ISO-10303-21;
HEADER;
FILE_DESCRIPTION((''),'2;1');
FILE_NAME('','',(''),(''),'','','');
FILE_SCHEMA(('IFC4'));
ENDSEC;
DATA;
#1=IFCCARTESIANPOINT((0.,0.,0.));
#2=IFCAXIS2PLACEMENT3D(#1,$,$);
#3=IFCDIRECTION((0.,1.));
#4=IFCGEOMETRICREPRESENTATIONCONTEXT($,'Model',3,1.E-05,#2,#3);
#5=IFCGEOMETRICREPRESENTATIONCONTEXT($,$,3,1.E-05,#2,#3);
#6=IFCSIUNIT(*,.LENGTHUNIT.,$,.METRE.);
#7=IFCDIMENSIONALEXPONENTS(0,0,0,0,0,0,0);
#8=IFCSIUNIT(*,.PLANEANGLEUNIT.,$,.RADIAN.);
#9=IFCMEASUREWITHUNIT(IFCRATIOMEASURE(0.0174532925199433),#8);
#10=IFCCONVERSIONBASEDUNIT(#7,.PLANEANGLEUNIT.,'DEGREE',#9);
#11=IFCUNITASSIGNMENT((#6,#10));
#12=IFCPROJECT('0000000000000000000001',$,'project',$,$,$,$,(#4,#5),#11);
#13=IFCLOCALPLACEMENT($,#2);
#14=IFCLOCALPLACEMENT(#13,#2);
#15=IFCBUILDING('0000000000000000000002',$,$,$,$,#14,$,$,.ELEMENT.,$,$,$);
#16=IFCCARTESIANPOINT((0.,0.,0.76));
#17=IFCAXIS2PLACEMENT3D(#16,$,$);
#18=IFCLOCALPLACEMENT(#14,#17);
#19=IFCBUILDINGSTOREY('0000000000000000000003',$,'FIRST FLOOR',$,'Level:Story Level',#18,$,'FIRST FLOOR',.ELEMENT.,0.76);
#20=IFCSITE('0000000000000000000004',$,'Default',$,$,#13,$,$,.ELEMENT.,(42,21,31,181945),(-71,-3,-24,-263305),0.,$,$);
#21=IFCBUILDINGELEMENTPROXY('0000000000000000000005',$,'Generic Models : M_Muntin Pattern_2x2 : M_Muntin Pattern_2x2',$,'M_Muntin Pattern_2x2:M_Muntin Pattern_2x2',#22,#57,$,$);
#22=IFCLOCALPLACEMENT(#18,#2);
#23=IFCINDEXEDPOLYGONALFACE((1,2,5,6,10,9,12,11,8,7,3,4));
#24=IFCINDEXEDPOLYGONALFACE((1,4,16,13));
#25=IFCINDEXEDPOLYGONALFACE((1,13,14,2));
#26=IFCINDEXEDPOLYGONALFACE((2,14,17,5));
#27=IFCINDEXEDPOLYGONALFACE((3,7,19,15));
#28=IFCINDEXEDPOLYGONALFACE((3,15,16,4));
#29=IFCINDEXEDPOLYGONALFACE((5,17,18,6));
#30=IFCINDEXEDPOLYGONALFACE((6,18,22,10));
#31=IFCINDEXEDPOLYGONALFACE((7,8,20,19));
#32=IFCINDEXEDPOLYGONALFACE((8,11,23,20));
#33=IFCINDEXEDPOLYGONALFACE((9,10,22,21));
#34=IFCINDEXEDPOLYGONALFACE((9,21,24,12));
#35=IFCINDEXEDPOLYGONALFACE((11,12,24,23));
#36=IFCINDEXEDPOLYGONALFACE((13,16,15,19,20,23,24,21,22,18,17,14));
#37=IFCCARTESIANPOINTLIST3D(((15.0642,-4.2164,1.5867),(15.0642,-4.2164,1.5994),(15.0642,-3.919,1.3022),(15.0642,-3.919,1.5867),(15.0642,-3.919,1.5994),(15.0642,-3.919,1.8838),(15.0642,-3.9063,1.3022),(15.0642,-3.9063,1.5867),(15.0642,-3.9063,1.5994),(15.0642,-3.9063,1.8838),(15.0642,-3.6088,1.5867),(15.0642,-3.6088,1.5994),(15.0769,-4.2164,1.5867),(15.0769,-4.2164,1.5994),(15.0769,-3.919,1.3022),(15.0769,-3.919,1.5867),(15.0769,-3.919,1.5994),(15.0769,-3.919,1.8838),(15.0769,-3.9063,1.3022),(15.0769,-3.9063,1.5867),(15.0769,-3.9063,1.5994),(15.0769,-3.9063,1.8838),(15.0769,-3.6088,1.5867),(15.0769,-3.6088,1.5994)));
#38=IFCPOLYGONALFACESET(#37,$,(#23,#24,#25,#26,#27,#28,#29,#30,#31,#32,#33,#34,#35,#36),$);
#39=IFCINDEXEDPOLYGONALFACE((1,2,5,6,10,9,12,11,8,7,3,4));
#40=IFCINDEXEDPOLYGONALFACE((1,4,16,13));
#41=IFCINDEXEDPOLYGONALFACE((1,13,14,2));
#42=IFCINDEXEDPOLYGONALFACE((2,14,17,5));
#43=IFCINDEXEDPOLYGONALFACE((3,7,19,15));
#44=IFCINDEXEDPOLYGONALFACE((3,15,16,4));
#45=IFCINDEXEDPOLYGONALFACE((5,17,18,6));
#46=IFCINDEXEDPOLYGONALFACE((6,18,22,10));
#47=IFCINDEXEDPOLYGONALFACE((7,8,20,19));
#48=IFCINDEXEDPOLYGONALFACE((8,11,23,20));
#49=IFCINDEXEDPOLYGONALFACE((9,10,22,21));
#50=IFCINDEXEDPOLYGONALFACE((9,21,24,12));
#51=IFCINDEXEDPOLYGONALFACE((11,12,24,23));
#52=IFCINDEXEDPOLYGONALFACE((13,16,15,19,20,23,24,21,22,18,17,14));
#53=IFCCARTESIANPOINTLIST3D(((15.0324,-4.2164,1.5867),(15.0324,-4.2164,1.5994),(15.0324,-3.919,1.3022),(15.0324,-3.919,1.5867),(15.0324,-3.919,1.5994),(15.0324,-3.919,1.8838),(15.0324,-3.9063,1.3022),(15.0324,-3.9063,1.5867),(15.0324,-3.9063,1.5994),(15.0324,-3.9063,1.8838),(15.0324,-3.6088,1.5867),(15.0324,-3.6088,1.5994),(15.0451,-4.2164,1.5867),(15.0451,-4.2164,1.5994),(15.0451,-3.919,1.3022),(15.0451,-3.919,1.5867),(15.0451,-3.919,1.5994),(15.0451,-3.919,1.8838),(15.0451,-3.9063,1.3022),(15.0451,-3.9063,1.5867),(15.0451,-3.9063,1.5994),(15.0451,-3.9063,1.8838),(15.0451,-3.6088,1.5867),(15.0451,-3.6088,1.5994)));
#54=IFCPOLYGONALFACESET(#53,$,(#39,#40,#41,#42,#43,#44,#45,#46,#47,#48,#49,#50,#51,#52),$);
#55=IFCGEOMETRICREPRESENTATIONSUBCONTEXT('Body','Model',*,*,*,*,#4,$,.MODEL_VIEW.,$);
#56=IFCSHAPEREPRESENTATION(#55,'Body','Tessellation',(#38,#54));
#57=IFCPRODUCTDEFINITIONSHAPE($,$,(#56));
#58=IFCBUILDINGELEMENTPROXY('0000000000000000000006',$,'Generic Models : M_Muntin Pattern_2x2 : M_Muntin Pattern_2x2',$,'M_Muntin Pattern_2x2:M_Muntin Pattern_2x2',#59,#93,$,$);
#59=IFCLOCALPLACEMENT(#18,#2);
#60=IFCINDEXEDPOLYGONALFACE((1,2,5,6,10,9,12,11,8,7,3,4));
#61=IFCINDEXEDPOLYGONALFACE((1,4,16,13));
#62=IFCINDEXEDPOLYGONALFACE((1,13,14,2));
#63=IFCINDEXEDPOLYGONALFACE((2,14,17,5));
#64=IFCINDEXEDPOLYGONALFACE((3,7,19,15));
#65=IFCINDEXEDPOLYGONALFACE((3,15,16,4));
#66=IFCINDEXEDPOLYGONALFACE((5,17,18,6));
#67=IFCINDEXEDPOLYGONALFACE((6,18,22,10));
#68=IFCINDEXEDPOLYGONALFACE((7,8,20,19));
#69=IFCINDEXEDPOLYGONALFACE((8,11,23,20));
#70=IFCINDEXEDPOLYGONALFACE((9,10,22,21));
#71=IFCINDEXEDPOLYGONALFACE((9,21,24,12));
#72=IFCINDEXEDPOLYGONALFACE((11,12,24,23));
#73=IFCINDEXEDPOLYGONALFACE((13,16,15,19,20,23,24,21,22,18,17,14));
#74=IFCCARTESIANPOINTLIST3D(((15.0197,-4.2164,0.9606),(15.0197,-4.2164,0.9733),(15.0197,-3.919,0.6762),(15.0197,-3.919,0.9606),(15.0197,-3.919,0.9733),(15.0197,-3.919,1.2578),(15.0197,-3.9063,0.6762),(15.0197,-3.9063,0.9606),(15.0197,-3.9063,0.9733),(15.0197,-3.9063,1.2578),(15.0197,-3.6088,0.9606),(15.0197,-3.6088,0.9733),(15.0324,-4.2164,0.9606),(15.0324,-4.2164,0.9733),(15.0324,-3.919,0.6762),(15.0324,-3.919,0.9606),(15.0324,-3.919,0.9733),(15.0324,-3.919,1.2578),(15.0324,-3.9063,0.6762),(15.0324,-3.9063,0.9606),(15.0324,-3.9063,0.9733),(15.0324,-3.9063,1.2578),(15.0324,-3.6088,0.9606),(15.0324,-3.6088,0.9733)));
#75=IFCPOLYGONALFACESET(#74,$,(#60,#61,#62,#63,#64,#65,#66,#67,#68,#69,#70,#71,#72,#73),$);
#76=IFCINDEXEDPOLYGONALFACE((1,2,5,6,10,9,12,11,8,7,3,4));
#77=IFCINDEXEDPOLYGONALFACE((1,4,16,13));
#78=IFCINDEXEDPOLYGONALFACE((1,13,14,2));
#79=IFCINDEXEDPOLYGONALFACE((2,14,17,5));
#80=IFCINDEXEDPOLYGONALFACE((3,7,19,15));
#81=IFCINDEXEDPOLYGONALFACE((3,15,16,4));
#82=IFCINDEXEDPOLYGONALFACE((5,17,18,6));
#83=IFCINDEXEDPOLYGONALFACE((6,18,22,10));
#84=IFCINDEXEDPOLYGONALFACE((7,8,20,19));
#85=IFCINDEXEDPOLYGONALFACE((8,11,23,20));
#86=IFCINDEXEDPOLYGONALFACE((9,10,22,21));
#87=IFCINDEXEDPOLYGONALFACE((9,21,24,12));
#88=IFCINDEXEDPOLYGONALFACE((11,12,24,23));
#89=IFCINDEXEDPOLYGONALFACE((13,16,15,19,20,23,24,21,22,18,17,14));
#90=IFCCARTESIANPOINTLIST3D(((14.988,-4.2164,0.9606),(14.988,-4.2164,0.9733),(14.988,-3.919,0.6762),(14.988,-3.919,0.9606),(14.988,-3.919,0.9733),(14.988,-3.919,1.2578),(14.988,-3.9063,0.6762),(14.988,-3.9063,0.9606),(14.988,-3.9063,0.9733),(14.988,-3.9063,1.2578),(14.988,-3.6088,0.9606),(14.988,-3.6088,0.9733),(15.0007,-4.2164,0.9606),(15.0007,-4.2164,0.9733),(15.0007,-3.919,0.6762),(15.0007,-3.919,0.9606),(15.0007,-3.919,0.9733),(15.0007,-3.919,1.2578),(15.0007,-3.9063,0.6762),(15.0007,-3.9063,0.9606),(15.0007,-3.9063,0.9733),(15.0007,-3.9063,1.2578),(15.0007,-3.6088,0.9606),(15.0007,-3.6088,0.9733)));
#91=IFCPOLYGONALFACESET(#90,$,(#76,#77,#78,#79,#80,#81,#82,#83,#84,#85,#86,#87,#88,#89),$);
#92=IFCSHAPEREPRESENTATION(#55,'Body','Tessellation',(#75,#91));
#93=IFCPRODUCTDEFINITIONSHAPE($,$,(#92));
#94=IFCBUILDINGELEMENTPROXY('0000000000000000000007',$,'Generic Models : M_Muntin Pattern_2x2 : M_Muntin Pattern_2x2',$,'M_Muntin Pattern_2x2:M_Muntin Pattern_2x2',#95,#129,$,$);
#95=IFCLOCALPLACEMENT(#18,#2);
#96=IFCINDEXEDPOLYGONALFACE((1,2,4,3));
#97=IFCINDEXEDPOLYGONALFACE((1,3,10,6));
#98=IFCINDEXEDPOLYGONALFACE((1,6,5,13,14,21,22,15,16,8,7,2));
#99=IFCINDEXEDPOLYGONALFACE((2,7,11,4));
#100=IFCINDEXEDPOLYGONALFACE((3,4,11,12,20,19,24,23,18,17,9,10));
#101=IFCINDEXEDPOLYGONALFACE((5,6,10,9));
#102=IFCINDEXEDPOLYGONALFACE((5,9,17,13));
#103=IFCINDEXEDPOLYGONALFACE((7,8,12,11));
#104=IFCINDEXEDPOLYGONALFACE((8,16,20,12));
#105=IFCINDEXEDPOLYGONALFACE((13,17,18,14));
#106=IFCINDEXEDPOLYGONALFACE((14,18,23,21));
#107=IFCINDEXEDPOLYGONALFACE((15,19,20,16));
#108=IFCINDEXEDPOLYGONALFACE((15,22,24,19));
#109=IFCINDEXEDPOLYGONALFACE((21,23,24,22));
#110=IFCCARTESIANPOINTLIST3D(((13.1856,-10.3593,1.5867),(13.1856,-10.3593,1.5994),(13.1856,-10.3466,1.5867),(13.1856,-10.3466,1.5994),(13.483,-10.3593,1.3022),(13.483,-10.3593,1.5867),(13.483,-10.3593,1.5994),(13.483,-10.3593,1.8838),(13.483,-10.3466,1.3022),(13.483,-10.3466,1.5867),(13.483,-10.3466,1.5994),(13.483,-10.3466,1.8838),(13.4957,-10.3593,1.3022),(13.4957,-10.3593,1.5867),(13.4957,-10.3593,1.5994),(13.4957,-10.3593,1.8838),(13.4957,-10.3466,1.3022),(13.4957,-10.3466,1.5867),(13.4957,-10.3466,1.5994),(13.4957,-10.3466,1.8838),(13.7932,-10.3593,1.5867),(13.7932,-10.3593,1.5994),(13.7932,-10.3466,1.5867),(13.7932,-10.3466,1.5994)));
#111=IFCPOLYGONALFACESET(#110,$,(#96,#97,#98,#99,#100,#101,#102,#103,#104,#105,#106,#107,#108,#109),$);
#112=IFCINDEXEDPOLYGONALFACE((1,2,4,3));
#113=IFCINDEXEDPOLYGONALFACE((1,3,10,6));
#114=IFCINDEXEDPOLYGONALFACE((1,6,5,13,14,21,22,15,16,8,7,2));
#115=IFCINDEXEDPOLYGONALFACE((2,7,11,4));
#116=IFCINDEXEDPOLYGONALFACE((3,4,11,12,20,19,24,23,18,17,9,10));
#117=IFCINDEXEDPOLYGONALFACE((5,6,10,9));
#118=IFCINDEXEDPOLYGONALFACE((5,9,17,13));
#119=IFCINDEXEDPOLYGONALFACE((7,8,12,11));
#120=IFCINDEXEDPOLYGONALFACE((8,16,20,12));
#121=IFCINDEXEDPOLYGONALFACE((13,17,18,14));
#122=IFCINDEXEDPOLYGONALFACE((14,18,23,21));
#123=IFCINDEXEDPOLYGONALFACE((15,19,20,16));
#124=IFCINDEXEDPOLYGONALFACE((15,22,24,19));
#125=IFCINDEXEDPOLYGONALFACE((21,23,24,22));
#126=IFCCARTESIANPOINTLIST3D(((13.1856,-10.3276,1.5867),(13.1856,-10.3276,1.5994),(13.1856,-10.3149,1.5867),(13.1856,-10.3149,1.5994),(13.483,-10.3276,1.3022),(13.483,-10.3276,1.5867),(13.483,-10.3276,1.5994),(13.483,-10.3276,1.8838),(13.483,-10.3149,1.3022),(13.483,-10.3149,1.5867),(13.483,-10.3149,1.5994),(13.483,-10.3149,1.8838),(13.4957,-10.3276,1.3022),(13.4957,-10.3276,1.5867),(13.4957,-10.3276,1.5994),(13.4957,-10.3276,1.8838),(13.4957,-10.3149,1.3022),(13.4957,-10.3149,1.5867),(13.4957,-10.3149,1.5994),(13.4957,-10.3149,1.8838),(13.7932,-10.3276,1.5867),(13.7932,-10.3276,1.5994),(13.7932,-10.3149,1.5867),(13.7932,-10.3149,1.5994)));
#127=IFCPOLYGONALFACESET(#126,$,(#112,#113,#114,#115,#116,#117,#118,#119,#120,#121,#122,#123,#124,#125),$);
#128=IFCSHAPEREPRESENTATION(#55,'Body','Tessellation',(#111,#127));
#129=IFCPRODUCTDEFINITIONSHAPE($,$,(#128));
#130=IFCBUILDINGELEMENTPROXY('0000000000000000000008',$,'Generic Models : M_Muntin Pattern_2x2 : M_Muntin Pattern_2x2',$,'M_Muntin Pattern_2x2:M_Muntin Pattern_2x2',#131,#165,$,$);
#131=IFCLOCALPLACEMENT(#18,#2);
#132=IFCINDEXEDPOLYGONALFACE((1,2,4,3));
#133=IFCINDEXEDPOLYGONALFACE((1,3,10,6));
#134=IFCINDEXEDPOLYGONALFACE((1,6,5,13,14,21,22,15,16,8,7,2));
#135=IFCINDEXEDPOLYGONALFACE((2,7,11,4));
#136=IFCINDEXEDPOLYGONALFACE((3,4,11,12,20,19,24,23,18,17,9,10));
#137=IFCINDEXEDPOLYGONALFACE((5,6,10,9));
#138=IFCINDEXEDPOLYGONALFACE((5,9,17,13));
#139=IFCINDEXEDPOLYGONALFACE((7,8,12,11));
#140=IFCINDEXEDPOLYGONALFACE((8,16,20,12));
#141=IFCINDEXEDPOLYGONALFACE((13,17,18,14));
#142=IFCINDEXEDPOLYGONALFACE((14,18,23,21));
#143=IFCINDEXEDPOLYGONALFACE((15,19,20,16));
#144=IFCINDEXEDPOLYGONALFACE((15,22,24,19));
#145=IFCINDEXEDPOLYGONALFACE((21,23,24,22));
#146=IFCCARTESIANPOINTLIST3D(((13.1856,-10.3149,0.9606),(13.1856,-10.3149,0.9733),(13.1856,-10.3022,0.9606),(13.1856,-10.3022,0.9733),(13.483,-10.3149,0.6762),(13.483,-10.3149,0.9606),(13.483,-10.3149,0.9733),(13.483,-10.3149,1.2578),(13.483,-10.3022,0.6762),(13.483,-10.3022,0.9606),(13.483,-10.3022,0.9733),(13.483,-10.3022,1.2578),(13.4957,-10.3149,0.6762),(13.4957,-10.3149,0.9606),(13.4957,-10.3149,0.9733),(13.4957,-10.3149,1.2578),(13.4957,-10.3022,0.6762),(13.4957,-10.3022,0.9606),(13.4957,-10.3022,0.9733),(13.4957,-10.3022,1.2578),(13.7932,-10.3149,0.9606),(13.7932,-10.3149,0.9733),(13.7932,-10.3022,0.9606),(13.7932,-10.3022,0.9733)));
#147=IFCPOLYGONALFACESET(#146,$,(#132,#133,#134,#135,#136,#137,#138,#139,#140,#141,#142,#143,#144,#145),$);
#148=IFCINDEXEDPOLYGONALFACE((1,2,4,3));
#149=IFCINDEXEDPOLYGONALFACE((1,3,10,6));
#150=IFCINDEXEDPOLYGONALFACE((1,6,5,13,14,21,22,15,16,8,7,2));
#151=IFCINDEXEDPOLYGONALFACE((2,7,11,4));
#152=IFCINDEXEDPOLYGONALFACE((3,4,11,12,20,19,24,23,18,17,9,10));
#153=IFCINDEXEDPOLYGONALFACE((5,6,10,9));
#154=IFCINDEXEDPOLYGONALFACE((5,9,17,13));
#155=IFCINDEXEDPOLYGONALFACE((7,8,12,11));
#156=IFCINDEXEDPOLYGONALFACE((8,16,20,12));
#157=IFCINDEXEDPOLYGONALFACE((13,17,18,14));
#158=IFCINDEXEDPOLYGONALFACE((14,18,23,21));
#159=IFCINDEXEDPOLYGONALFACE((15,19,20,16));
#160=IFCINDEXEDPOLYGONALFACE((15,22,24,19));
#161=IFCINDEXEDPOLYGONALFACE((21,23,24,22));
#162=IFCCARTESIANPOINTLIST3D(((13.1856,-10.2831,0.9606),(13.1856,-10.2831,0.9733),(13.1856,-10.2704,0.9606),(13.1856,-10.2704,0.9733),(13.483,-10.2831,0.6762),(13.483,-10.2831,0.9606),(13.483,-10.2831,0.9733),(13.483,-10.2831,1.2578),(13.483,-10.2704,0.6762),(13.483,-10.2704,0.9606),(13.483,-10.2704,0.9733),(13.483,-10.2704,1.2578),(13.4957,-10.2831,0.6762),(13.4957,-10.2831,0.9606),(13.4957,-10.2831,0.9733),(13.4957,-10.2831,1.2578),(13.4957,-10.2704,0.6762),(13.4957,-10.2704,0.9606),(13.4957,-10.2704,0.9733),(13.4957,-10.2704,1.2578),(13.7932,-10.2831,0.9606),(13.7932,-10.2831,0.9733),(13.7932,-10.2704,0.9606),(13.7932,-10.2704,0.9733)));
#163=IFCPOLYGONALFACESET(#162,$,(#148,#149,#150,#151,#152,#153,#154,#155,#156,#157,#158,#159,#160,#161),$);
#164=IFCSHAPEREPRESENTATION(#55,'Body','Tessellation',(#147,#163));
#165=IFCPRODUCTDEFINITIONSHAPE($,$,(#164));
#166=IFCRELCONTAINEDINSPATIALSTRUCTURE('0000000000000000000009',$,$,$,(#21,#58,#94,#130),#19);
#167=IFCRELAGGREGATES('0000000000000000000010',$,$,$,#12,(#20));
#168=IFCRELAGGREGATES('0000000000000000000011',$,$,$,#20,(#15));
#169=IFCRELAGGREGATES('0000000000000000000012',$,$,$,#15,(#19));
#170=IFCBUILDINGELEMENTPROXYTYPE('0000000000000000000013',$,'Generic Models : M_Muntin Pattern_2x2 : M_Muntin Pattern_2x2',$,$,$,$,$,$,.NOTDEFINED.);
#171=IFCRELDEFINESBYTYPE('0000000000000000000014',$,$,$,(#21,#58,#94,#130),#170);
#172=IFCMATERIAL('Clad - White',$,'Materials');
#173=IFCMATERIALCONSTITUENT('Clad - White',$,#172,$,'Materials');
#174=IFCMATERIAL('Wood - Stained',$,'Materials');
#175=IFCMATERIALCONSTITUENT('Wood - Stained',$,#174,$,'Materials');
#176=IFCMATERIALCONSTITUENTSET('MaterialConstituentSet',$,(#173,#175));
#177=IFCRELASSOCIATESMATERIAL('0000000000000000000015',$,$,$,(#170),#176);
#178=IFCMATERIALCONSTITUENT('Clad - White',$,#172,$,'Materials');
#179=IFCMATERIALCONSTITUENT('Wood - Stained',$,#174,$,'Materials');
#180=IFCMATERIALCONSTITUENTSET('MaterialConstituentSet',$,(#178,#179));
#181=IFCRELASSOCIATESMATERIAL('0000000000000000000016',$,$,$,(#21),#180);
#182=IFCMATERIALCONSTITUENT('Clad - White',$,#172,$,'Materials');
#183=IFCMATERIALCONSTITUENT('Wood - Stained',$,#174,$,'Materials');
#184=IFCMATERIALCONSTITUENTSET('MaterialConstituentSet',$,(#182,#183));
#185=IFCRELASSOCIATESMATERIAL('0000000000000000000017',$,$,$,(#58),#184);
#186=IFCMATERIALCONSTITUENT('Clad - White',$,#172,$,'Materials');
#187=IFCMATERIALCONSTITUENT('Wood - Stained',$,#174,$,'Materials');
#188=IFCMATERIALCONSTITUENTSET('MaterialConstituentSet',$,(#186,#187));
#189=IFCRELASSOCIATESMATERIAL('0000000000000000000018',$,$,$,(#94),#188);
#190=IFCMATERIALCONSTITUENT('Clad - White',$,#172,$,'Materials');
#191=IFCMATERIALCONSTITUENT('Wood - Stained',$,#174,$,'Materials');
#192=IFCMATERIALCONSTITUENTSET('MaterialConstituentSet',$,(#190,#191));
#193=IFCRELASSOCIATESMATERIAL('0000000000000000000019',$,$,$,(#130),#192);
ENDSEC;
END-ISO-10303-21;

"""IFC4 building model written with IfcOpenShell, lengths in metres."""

from ifc_helpers import new_model, entity, si_unit, converted_unit, direction, frame, origin, place, context, subcontext, project, spatial, polyline, outline, extrude, source, transform, mapped, material, constituent, constituent_set, type_object, type_shapes, element, save


model = new_model("IFC4")

# Units and contexts
model_context = context("Model", 3, precision=1e-05, world=origin(), true_north=direction((0.0, 1.0)))
context_of_model = context(None, 3, precision=1e-05, world=origin(), true_north=direction((0.0, 1.0)))
body_context = subcontext(model_context, "Body", "Model", "MODEL_VIEW")
ifc_project = project(units=[si_unit("LENGTHUNIT", "METRE"), converted_unit("PLANEANGLEUNIT", "DEGREE", entity("IfcRatioMeasure", 0.0174532925199433), si_unit("PLANEANGLEUNIT", "RADIAN"), dimensions=[0, 0, 0, 0, 0, 0, 0])], contexts=[model_context, context_of_model])

# Site, building, storey
site_placement = place(None, origin())
site = spatial("IfcSite", under=ifc_project, at=site_placement, Name="Default", CompositionType="ELEMENT", RefLatitude=(42, 21, 31, 181945), RefLongitude=(-71, -3, -24, -263305), RefElevation=0.0)
building_placement = place(site_placement, origin())
building = spatial("IfcBuilding", under=site, at=building_placement, CompositionType="ELEMENT")
storey_placement = place(building_placement, frame((0.0, 0.0, 0.76)))
storey = spatial("IfcBuildingStorey", under=building, at=storey_placement, Name="FIRST FLOOR", ObjectType="Level:Story Level", LongName="FIRST FLOOR", CompositionType="ELEMENT", Elevation=0.76)

# Shared definitions
ifc_material_1 = material(Name="Wood - Stained", Category="Materials")

# Building element proxies
ifc_material_2 = material(Name="Clad - White", Category="Materials")
ifc_constituent_1 = constituent(ifc_material_2, Name="Clad - White", Category="Materials")
ifc_constituent_2 = constituent(ifc_material_1, Name="Wood - Stained", Category="Materials")
ifc_constituent_set_1 = constituent_set(constituents=[ifc_constituent_1, ifc_constituent_2], Name="MaterialConstituentSet")
ifc_constituent_3 = constituent(ifc_material_2, Name="Clad - White", Category="Materials")
ifc_constituent_4 = constituent(ifc_material_1, Name="Wood - Stained", Category="Materials")
ifc_constituent_set_2 = constituent_set(constituents=[ifc_constituent_3, ifc_constituent_4], Name="MaterialConstituentSet")
building_element_proxy_type_1 = type_object("IfcBuildingElementProxyType", Name="Generic Models : M_Muntin Pattern_2x2 : M_Muntin Pattern_2x2", PredefinedType="NOTDEFINED", material=ifc_constituent_set_2)
shared_shape_1 = source(origin(), body_context, "Body", "SweptSolid", [
    extrude(outline(polyline([(0.0064, -0.0064), (0.2908, -0.0064), (0.2908, 0.0063), (0.0064, 0.0063), (0.0064, 0.3038), (-0.0063, 0.3038), (-0.0063, 0.0063), (-0.2908, 0.0063), (-0.2908, -0.0064), (-0.0063, -0.0064), (-0.0063, -0.3038), (0.0064, -0.3038), (0.0064, -0.0064)])), frame((0.0, 0.0095, 0.2908), z_axis=(0.0, 1.0, 0.0), x_axis=(0.0, 0.0, 1.0)), (0.0, 0.0, 1.0), 0.0127),
    extrude(outline(polyline([(0.0064, -0.0064), (0.2908, -0.0064), (0.2908, 0.0063), (0.0064, 0.0063), (0.0064, 0.3038), (-0.0063, 0.3038), (-0.0063, 0.0063), (-0.2908, 0.0063), (-0.2908, -0.0064), (-0.0063, -0.0064), (-0.0063, -0.3038), (0.0064, -0.3038), (0.0064, -0.0064)])), frame((0.0, -0.0222, 0.2908), z_axis=(0.0, 1.0, 0.0), x_axis=(0.0, 0.0, 1.0)), (0.0, 0.0, 1.0), 0.0127),
])
type_shapes(building_element_proxy_type_1, [shared_shape_1])
proxy_1_placement = place(storey_placement, frame((15.0546, -3.9126, 1.3022), z_axis=(0.0, 0.0, 1.0), x_axis=(0.0, -1.0, 0.0)))
element("IfcBuildingElementProxy", 1, at=proxy_1_placement, inside=storey, type_object=building_element_proxy_type_1, material=ifc_constituent_set_1, Name="Generic Models : M_Muntin Pattern_2x2 : M_Muntin Pattern_2x2", ObjectType="M_Muntin Pattern_2x2:M_Muntin Pattern_2x2", context=body_context, shape_type="MappedRepresentation", body=[
    mapped(shared_shape_1, transform((0.0, 0.0, 0.0), scale=1.0)),
])
ifc_constituent_5 = constituent(ifc_material_2, Name="Clad - White", Category="Materials")
ifc_constituent_6 = constituent(ifc_material_1, Name="Wood - Stained", Category="Materials")
ifc_constituent_set_3 = constituent_set(constituents=[ifc_constituent_5, ifc_constituent_6], Name="MaterialConstituentSet")
proxy_2_placement = place(storey_placement, frame((15.0102, -3.9126, 0.6762), z_axis=(0.0, 0.0, 1.0), x_axis=(0.0, -1.0, 0.0)))
element("IfcBuildingElementProxy", 2, at=proxy_2_placement, inside=storey, type_object=building_element_proxy_type_1, material=ifc_constituent_set_3, Name="Generic Models : M_Muntin Pattern_2x2 : M_Muntin Pattern_2x2", ObjectType="M_Muntin Pattern_2x2:M_Muntin Pattern_2x2", context=body_context, shape_type="MappedRepresentation", body=[
    mapped(shared_shape_1, transform((0.0, 0.0, 0.0), scale=1.0)),
])
ifc_constituent_7 = constituent(ifc_material_2, Name="Clad - White", Category="Materials")
ifc_constituent_8 = constituent(ifc_material_1, Name="Wood - Stained", Category="Materials")
ifc_constituent_set_4 = constituent_set(constituents=[ifc_constituent_7, ifc_constituent_8], Name="MaterialConstituentSet")
proxy_3_placement = place(storey_placement, frame((13.4894, -10.3371, 1.3022), z_axis=(0.0, 0.0, 1.0), x_axis=(-1.0, 0.0, 0.0)))
element("IfcBuildingElementProxy", 3, at=proxy_3_placement, inside=storey, type_object=building_element_proxy_type_1, material=ifc_constituent_set_4, Name="Generic Models : M_Muntin Pattern_2x2 : M_Muntin Pattern_2x2", ObjectType="M_Muntin Pattern_2x2:M_Muntin Pattern_2x2", context=body_context, shape_type="MappedRepresentation", body=[
    mapped(shared_shape_1, transform((0.0, 0.0, 0.0), scale=1.0)),
])
ifc_constituent_9 = constituent(ifc_material_2, Name="Clad - White", Category="Materials")
ifc_constituent_10 = constituent(ifc_material_1, Name="Wood - Stained", Category="Materials")
ifc_constituent_set_5 = constituent_set(constituents=[ifc_constituent_9, ifc_constituent_10], Name="MaterialConstituentSet")
proxy_4_placement = place(storey_placement, frame((13.4894, -10.2926, 0.6762), z_axis=(0.0, 0.0, 1.0), x_axis=(-1.0, 0.0, 0.0)))
element("IfcBuildingElementProxy", 4, at=proxy_4_placement, inside=storey, type_object=building_element_proxy_type_1, material=ifc_constituent_set_5, Name="Generic Models : M_Muntin Pattern_2x2 : M_Muntin Pattern_2x2", ObjectType="M_Muntin Pattern_2x2:M_Muntin Pattern_2x2", context=body_context, shape_type="MappedRepresentation", body=[
    mapped(shared_shape_1, transform((0.0, 0.0, 0.0), scale=1.0)),
])

save(model, "model.ifc")
